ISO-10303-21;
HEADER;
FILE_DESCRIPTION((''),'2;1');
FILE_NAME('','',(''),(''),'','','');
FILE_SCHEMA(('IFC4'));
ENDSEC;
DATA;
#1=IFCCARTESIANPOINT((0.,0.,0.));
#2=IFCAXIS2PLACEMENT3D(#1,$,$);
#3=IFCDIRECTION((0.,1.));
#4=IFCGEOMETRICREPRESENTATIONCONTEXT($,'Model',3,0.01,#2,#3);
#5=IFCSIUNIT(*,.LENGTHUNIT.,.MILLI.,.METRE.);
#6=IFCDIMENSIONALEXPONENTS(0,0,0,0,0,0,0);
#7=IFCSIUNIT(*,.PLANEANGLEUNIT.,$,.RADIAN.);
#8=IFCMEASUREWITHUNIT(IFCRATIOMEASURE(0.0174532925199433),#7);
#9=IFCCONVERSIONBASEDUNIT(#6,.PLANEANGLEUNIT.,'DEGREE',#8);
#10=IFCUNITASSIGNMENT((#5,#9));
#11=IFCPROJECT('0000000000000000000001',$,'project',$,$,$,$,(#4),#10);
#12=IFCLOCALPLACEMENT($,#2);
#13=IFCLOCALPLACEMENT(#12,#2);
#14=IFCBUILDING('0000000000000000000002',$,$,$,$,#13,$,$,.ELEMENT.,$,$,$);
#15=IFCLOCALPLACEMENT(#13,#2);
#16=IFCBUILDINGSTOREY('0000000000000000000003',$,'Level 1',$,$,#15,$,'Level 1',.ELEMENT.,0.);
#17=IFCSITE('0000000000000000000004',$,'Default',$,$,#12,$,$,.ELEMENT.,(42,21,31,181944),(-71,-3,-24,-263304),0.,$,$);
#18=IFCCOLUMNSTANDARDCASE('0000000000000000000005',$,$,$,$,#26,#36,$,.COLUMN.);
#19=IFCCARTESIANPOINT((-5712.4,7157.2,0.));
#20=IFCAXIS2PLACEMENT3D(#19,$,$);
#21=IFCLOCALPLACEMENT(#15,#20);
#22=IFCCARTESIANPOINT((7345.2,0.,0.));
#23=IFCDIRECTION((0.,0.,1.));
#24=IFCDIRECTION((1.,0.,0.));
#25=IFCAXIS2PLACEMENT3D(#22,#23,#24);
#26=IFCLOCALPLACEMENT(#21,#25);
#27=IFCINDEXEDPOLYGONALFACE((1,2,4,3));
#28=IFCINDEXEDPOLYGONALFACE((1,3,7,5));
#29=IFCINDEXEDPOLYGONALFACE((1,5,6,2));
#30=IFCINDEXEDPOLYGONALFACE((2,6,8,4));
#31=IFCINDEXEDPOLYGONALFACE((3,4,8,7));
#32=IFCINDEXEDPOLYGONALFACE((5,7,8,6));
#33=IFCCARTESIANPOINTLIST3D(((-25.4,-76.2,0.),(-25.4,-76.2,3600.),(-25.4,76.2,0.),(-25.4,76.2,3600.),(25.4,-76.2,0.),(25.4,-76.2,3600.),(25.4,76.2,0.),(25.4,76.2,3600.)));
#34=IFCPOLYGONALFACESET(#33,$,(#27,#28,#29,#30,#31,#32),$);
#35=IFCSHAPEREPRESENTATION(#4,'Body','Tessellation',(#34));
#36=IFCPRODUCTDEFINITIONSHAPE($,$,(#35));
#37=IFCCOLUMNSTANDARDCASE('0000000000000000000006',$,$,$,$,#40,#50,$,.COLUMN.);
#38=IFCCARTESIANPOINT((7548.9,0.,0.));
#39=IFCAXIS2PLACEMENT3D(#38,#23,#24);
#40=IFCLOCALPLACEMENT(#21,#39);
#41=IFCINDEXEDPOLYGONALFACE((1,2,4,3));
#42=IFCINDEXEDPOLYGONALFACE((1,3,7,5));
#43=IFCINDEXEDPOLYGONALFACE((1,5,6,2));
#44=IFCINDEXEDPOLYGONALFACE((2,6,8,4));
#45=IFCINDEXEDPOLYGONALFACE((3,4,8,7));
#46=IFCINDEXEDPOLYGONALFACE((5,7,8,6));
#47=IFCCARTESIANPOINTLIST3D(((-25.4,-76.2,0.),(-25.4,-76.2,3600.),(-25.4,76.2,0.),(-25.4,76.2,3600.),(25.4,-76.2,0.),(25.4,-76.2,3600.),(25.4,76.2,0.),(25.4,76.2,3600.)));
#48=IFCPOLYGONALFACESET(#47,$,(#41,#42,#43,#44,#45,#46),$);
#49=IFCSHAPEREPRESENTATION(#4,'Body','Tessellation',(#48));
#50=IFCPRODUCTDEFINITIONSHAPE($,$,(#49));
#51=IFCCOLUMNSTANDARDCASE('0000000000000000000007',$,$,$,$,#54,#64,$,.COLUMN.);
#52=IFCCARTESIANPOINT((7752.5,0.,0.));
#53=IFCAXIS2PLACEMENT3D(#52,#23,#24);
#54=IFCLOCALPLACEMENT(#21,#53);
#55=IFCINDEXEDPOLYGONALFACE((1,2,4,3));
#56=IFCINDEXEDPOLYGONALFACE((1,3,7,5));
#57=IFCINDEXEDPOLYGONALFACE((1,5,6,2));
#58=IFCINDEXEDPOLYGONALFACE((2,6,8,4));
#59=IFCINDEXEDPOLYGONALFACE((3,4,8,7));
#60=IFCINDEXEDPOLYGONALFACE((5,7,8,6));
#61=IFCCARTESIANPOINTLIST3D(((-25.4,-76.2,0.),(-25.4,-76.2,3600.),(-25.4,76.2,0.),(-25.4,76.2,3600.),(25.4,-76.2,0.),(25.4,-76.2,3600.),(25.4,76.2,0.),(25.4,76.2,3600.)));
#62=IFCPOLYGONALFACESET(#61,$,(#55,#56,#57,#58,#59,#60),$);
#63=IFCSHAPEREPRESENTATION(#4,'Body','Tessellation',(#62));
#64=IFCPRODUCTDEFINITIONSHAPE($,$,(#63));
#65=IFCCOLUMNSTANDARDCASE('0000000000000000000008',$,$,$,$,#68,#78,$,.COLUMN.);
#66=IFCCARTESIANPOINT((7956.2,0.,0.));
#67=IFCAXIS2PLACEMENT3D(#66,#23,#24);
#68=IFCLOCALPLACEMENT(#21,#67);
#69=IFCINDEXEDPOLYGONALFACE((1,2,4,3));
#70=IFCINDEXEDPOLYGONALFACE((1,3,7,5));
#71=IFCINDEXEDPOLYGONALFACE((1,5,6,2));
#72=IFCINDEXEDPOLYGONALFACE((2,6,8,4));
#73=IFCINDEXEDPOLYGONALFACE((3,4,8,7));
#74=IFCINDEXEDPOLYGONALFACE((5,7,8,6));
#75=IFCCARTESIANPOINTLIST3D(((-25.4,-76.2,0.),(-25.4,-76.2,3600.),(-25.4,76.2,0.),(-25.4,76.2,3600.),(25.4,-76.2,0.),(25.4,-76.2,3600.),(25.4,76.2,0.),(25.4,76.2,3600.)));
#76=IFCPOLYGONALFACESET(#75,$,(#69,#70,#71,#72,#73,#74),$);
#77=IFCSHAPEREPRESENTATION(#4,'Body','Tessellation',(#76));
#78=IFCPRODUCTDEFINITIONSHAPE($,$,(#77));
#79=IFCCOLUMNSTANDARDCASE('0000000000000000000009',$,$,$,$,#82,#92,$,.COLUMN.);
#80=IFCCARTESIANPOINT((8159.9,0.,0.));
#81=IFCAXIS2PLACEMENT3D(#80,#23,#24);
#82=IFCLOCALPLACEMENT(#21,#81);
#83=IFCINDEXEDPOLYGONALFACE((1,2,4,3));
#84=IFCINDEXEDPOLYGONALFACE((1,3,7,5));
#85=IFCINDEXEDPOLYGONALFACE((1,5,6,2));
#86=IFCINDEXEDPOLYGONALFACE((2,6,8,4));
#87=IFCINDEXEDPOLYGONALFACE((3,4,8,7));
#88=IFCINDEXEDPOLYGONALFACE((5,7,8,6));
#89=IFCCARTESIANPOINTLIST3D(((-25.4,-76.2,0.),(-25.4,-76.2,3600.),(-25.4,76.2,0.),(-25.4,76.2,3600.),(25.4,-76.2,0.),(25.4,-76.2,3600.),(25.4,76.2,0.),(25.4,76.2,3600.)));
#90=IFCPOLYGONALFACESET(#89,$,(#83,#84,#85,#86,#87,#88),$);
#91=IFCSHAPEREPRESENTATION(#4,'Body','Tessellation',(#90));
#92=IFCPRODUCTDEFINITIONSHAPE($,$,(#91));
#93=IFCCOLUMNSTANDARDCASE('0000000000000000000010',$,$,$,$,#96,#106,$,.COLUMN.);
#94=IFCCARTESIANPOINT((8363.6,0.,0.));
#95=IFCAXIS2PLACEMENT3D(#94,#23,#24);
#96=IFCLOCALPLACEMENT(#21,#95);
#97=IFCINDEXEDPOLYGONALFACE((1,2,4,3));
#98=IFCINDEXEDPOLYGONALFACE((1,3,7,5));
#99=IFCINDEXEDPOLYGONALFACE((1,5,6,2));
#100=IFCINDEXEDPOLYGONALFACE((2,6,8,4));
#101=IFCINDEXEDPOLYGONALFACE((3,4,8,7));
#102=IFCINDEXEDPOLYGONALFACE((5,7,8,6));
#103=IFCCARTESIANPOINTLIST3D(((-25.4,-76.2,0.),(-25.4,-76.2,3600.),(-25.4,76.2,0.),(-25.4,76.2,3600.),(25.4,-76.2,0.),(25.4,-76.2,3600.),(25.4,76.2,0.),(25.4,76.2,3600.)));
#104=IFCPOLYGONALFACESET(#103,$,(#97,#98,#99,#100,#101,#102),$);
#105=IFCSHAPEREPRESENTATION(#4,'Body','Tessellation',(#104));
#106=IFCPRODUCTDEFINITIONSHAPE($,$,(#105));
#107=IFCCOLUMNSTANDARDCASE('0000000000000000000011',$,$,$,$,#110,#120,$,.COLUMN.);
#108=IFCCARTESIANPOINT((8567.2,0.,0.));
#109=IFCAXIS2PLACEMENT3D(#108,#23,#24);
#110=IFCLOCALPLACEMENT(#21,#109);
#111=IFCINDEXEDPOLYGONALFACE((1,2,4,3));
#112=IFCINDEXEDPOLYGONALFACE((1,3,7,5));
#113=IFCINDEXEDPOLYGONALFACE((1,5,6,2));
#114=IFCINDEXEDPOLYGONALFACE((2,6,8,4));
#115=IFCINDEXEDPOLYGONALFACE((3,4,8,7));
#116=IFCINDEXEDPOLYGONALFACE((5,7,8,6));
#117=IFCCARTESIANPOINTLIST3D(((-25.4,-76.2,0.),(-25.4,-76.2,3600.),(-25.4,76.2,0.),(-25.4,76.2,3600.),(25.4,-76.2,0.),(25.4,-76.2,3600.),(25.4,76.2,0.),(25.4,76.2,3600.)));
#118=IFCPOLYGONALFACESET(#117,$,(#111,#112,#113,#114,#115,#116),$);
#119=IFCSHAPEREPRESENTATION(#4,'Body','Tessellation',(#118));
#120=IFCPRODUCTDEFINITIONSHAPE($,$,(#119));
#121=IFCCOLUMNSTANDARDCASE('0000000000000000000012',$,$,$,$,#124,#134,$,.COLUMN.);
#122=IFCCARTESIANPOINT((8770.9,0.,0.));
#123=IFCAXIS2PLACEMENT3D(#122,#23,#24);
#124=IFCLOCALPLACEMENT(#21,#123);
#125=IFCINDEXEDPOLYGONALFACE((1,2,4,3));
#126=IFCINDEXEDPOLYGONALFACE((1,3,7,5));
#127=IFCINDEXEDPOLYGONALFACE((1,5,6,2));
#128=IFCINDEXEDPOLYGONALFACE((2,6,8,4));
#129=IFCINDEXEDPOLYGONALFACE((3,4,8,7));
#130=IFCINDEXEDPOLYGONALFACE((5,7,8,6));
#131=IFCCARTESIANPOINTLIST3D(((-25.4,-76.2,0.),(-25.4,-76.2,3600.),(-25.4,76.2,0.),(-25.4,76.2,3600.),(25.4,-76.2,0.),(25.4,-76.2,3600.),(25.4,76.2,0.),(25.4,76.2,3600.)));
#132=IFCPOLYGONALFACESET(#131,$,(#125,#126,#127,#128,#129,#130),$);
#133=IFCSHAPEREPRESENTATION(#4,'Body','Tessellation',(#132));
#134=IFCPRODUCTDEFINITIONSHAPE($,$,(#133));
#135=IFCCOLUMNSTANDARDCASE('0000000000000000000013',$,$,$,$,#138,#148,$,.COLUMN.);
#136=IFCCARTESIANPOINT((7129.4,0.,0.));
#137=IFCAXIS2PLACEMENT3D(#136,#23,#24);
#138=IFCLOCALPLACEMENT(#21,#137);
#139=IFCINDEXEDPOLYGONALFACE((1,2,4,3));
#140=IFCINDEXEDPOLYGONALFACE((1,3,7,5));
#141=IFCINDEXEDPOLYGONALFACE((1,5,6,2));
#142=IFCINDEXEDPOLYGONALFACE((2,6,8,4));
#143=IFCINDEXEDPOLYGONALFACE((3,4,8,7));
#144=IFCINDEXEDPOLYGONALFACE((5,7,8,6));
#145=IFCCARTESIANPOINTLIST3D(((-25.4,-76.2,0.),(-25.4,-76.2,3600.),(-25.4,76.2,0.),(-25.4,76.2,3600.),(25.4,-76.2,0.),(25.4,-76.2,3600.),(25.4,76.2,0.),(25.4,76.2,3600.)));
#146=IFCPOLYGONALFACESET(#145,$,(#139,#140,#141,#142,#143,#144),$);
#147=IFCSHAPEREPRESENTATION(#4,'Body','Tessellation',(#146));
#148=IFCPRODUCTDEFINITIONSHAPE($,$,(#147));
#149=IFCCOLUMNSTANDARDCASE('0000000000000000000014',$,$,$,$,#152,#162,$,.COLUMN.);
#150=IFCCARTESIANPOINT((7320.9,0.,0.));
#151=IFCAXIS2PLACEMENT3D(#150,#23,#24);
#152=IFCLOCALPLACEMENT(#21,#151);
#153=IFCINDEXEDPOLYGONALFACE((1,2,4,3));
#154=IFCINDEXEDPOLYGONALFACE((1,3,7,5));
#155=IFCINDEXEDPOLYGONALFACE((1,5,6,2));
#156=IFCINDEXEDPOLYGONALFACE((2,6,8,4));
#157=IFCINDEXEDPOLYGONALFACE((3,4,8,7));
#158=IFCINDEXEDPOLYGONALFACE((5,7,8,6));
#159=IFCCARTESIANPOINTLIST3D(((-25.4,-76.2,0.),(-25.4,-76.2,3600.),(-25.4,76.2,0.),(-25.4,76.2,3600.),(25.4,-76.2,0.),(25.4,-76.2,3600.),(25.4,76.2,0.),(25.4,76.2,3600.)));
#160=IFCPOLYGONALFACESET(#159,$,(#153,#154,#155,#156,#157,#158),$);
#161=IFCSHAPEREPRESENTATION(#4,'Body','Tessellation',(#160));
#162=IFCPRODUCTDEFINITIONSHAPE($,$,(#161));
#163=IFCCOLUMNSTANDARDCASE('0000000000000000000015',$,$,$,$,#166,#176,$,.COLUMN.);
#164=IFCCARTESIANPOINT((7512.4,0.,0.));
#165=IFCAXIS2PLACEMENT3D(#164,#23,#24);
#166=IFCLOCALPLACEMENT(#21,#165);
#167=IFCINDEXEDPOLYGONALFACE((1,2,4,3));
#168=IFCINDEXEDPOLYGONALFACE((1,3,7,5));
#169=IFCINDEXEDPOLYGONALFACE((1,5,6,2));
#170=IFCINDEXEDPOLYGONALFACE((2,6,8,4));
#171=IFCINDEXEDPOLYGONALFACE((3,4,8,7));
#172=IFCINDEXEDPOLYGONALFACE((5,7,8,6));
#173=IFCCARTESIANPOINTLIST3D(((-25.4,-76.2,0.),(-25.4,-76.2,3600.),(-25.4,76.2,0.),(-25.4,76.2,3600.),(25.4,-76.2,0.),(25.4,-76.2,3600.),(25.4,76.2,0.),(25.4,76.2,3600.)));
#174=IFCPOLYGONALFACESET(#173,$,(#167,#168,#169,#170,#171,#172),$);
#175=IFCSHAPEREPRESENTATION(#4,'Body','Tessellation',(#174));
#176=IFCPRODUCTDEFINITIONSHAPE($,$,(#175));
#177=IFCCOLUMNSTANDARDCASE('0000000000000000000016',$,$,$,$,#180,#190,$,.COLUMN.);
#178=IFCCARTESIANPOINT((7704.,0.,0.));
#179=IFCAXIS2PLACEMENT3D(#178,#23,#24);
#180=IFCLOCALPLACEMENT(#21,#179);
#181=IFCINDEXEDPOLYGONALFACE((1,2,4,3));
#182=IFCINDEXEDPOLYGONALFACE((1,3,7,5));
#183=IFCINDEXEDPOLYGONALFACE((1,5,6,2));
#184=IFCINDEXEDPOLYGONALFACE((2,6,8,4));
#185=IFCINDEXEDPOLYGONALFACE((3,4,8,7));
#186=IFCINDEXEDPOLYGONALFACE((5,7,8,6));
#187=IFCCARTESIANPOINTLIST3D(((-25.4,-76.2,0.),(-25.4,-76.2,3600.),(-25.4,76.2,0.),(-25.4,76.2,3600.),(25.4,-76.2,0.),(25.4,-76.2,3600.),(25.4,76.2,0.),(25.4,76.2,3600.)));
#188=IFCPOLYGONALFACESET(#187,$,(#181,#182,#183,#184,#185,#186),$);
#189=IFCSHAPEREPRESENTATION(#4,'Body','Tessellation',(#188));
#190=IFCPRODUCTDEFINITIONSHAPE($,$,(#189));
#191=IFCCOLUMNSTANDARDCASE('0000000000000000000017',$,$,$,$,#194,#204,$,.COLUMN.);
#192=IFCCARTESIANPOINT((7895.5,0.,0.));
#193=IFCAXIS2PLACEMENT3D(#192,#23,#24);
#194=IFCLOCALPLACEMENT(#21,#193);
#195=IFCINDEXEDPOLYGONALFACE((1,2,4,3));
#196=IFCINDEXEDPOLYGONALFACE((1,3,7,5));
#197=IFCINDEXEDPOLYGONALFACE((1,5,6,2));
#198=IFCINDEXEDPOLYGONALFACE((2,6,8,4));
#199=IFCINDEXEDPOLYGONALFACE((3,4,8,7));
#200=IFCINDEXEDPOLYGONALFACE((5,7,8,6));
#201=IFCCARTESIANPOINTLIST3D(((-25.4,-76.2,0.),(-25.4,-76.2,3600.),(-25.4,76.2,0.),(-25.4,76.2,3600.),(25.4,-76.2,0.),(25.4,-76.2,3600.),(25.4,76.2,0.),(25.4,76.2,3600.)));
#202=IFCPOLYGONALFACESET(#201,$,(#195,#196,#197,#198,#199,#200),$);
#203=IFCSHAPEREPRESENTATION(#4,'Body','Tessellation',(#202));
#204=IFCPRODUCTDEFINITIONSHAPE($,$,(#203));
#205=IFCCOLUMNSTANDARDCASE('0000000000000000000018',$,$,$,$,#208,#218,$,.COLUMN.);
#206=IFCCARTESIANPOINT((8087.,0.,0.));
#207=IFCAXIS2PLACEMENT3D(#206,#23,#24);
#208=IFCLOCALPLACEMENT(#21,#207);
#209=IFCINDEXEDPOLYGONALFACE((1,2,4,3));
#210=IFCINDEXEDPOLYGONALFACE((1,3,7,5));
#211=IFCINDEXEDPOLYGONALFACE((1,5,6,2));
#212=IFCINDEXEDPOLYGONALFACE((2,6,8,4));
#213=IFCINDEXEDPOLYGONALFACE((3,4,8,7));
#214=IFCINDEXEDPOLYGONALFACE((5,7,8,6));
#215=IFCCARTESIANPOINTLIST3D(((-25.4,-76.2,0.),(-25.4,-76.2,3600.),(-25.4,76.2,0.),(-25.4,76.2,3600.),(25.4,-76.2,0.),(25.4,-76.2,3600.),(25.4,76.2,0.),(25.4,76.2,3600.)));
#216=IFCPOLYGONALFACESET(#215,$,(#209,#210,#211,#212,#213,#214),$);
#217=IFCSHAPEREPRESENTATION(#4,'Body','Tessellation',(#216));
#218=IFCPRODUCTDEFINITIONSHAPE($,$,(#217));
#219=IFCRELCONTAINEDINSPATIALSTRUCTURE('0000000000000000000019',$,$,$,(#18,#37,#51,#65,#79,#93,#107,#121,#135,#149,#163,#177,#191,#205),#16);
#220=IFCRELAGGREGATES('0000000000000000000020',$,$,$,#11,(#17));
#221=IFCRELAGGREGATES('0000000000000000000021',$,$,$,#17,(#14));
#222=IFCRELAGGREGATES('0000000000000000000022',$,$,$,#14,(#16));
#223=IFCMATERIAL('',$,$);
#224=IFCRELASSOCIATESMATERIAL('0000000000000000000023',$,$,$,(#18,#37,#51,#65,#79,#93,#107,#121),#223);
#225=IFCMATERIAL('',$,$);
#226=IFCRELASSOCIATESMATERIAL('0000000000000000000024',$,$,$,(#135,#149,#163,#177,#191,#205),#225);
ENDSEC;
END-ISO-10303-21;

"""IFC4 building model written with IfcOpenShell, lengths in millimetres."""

from ifc_helpers import new_model, entity, si_unit, converted_unit, direction, frame, origin, place, context, project, spatial, rectangle, extrude, material, element, save


model = new_model("IFC4")

# Units and contexts
model_context = context("Model", 3, precision=0.01, world=origin(), true_north=direction((0.0, 1.0)))
ifc_project = project(units=[si_unit("LENGTHUNIT", "METRE", prefix="MILLI"), converted_unit("PLANEANGLEUNIT", "DEGREE", entity("IfcRatioMeasure", 0.0174532925199433), si_unit("PLANEANGLEUNIT", "RADIAN"), dimensions=[0, 0, 0, 0, 0, 0, 0])], contexts=[model_context])

# Site, building, storey
site_placement = place(None, origin())
site = spatial("IfcSite", under=ifc_project, at=site_placement, Name="Default", CompositionType="ELEMENT", RefLatitude=(42, 21, 31, 181944), RefLongitude=(-71, -3, -24, -263304), RefElevation=0.0)
building_placement = place(site_placement, origin())
building = spatial("IfcBuilding", under=site, at=building_placement, CompositionType="ELEMENT")
storey_placement = place(building_placement, origin())
storey = spatial("IfcBuildingStorey", under=building, at=storey_placement, Name="Level 1", LongName="Level 1", CompositionType="ELEMENT", Elevation=0.0)

# Columns
ifc_material_1 = material(Name="")
ifc_material_2 = material(Name="")
placement_1 = place(storey_placement, frame((-5712.4, 7157.2, 0.0)))
for number, where, z_axis, x_axis in (
    (1, (7345.2, 0.0, 0.0), (0.0, 0.0, 1.0), (1.0, 0.0, 0.0)),
    (2, (7548.9, 0.0, 0.0), (0.0, 0.0, 1.0), (1.0, 0.0, 0.0)),
    (3, (7752.5, 0.0, 0.0), (0.0, 0.0, 1.0), (1.0, 0.0, 0.0)),
    (4, (7956.2, 0.0, 0.0), (0.0, 0.0, 1.0), (1.0, 0.0, 0.0)),
    (5, (8159.9, 0.0, 0.0), (0.0, 0.0, 1.0), (1.0, 0.0, 0.0)),
    (6, (8363.6, 0.0, 0.0), (0.0, 0.0, 1.0), (1.0, 0.0, 0.0)),
    (7, (8567.2, 0.0, 0.0), (0.0, 0.0, 1.0), (1.0, 0.0, 0.0)),
    (8, (8770.9, 0.0, 0.0), (0.0, 0.0, 1.0), (1.0, 0.0, 0.0)),
):
    element("IfcColumnStandardCase", number, at=place(placement_1, frame(where, z_axis=z_axis, x_axis=x_axis)), inside=storey, material=ifc_material_1, PredefinedType="COLUMN", context=model_context, shape_type="SweptSolid", body=[
        extrude(rectangle(XDim=50.8, YDim=152.4), origin(), (0.0, 0.0, 1.0), 3600.0),
    ])
for number, where, z_axis, x_axis in (
    (9, (7129.4, 0.0, 0.0), (0.0, 0.0, 1.0), (1.0, 0.0, 0.0)),
    (10, (7320.9, 0.0, 0.0), (0.0, 0.0, 1.0), (1.0, 0.0, 0.0)),
    (11, (7512.4, 0.0, 0.0), (0.0, 0.0, 1.0), (1.0, 0.0, 0.0)),
    (12, (7704.0, 0.0, 0.0), (0.0, 0.0, 1.0), (1.0, 0.0, 0.0)),
    (13, (7895.5, 0.0, 0.0), (0.0, 0.0, 1.0), (1.0, 0.0, 0.0)),
    (14, (8087.0, 0.0, 0.0), (0.0, 0.0, 1.0), (1.0, 0.0, 0.0)),
):
    element("IfcColumnStandardCase", number, at=place(placement_1, frame(where, z_axis=z_axis, x_axis=x_axis)), inside=storey, material=ifc_material_2, PredefinedType="COLUMN", context=model_context, shape_type="SweptSolid", body=[
        extrude(rectangle(XDim=50.8, YDim=152.4), origin(), (0.0, 0.0, 1.0), 3600.0),
    ])

save(model, "model.ifc")
